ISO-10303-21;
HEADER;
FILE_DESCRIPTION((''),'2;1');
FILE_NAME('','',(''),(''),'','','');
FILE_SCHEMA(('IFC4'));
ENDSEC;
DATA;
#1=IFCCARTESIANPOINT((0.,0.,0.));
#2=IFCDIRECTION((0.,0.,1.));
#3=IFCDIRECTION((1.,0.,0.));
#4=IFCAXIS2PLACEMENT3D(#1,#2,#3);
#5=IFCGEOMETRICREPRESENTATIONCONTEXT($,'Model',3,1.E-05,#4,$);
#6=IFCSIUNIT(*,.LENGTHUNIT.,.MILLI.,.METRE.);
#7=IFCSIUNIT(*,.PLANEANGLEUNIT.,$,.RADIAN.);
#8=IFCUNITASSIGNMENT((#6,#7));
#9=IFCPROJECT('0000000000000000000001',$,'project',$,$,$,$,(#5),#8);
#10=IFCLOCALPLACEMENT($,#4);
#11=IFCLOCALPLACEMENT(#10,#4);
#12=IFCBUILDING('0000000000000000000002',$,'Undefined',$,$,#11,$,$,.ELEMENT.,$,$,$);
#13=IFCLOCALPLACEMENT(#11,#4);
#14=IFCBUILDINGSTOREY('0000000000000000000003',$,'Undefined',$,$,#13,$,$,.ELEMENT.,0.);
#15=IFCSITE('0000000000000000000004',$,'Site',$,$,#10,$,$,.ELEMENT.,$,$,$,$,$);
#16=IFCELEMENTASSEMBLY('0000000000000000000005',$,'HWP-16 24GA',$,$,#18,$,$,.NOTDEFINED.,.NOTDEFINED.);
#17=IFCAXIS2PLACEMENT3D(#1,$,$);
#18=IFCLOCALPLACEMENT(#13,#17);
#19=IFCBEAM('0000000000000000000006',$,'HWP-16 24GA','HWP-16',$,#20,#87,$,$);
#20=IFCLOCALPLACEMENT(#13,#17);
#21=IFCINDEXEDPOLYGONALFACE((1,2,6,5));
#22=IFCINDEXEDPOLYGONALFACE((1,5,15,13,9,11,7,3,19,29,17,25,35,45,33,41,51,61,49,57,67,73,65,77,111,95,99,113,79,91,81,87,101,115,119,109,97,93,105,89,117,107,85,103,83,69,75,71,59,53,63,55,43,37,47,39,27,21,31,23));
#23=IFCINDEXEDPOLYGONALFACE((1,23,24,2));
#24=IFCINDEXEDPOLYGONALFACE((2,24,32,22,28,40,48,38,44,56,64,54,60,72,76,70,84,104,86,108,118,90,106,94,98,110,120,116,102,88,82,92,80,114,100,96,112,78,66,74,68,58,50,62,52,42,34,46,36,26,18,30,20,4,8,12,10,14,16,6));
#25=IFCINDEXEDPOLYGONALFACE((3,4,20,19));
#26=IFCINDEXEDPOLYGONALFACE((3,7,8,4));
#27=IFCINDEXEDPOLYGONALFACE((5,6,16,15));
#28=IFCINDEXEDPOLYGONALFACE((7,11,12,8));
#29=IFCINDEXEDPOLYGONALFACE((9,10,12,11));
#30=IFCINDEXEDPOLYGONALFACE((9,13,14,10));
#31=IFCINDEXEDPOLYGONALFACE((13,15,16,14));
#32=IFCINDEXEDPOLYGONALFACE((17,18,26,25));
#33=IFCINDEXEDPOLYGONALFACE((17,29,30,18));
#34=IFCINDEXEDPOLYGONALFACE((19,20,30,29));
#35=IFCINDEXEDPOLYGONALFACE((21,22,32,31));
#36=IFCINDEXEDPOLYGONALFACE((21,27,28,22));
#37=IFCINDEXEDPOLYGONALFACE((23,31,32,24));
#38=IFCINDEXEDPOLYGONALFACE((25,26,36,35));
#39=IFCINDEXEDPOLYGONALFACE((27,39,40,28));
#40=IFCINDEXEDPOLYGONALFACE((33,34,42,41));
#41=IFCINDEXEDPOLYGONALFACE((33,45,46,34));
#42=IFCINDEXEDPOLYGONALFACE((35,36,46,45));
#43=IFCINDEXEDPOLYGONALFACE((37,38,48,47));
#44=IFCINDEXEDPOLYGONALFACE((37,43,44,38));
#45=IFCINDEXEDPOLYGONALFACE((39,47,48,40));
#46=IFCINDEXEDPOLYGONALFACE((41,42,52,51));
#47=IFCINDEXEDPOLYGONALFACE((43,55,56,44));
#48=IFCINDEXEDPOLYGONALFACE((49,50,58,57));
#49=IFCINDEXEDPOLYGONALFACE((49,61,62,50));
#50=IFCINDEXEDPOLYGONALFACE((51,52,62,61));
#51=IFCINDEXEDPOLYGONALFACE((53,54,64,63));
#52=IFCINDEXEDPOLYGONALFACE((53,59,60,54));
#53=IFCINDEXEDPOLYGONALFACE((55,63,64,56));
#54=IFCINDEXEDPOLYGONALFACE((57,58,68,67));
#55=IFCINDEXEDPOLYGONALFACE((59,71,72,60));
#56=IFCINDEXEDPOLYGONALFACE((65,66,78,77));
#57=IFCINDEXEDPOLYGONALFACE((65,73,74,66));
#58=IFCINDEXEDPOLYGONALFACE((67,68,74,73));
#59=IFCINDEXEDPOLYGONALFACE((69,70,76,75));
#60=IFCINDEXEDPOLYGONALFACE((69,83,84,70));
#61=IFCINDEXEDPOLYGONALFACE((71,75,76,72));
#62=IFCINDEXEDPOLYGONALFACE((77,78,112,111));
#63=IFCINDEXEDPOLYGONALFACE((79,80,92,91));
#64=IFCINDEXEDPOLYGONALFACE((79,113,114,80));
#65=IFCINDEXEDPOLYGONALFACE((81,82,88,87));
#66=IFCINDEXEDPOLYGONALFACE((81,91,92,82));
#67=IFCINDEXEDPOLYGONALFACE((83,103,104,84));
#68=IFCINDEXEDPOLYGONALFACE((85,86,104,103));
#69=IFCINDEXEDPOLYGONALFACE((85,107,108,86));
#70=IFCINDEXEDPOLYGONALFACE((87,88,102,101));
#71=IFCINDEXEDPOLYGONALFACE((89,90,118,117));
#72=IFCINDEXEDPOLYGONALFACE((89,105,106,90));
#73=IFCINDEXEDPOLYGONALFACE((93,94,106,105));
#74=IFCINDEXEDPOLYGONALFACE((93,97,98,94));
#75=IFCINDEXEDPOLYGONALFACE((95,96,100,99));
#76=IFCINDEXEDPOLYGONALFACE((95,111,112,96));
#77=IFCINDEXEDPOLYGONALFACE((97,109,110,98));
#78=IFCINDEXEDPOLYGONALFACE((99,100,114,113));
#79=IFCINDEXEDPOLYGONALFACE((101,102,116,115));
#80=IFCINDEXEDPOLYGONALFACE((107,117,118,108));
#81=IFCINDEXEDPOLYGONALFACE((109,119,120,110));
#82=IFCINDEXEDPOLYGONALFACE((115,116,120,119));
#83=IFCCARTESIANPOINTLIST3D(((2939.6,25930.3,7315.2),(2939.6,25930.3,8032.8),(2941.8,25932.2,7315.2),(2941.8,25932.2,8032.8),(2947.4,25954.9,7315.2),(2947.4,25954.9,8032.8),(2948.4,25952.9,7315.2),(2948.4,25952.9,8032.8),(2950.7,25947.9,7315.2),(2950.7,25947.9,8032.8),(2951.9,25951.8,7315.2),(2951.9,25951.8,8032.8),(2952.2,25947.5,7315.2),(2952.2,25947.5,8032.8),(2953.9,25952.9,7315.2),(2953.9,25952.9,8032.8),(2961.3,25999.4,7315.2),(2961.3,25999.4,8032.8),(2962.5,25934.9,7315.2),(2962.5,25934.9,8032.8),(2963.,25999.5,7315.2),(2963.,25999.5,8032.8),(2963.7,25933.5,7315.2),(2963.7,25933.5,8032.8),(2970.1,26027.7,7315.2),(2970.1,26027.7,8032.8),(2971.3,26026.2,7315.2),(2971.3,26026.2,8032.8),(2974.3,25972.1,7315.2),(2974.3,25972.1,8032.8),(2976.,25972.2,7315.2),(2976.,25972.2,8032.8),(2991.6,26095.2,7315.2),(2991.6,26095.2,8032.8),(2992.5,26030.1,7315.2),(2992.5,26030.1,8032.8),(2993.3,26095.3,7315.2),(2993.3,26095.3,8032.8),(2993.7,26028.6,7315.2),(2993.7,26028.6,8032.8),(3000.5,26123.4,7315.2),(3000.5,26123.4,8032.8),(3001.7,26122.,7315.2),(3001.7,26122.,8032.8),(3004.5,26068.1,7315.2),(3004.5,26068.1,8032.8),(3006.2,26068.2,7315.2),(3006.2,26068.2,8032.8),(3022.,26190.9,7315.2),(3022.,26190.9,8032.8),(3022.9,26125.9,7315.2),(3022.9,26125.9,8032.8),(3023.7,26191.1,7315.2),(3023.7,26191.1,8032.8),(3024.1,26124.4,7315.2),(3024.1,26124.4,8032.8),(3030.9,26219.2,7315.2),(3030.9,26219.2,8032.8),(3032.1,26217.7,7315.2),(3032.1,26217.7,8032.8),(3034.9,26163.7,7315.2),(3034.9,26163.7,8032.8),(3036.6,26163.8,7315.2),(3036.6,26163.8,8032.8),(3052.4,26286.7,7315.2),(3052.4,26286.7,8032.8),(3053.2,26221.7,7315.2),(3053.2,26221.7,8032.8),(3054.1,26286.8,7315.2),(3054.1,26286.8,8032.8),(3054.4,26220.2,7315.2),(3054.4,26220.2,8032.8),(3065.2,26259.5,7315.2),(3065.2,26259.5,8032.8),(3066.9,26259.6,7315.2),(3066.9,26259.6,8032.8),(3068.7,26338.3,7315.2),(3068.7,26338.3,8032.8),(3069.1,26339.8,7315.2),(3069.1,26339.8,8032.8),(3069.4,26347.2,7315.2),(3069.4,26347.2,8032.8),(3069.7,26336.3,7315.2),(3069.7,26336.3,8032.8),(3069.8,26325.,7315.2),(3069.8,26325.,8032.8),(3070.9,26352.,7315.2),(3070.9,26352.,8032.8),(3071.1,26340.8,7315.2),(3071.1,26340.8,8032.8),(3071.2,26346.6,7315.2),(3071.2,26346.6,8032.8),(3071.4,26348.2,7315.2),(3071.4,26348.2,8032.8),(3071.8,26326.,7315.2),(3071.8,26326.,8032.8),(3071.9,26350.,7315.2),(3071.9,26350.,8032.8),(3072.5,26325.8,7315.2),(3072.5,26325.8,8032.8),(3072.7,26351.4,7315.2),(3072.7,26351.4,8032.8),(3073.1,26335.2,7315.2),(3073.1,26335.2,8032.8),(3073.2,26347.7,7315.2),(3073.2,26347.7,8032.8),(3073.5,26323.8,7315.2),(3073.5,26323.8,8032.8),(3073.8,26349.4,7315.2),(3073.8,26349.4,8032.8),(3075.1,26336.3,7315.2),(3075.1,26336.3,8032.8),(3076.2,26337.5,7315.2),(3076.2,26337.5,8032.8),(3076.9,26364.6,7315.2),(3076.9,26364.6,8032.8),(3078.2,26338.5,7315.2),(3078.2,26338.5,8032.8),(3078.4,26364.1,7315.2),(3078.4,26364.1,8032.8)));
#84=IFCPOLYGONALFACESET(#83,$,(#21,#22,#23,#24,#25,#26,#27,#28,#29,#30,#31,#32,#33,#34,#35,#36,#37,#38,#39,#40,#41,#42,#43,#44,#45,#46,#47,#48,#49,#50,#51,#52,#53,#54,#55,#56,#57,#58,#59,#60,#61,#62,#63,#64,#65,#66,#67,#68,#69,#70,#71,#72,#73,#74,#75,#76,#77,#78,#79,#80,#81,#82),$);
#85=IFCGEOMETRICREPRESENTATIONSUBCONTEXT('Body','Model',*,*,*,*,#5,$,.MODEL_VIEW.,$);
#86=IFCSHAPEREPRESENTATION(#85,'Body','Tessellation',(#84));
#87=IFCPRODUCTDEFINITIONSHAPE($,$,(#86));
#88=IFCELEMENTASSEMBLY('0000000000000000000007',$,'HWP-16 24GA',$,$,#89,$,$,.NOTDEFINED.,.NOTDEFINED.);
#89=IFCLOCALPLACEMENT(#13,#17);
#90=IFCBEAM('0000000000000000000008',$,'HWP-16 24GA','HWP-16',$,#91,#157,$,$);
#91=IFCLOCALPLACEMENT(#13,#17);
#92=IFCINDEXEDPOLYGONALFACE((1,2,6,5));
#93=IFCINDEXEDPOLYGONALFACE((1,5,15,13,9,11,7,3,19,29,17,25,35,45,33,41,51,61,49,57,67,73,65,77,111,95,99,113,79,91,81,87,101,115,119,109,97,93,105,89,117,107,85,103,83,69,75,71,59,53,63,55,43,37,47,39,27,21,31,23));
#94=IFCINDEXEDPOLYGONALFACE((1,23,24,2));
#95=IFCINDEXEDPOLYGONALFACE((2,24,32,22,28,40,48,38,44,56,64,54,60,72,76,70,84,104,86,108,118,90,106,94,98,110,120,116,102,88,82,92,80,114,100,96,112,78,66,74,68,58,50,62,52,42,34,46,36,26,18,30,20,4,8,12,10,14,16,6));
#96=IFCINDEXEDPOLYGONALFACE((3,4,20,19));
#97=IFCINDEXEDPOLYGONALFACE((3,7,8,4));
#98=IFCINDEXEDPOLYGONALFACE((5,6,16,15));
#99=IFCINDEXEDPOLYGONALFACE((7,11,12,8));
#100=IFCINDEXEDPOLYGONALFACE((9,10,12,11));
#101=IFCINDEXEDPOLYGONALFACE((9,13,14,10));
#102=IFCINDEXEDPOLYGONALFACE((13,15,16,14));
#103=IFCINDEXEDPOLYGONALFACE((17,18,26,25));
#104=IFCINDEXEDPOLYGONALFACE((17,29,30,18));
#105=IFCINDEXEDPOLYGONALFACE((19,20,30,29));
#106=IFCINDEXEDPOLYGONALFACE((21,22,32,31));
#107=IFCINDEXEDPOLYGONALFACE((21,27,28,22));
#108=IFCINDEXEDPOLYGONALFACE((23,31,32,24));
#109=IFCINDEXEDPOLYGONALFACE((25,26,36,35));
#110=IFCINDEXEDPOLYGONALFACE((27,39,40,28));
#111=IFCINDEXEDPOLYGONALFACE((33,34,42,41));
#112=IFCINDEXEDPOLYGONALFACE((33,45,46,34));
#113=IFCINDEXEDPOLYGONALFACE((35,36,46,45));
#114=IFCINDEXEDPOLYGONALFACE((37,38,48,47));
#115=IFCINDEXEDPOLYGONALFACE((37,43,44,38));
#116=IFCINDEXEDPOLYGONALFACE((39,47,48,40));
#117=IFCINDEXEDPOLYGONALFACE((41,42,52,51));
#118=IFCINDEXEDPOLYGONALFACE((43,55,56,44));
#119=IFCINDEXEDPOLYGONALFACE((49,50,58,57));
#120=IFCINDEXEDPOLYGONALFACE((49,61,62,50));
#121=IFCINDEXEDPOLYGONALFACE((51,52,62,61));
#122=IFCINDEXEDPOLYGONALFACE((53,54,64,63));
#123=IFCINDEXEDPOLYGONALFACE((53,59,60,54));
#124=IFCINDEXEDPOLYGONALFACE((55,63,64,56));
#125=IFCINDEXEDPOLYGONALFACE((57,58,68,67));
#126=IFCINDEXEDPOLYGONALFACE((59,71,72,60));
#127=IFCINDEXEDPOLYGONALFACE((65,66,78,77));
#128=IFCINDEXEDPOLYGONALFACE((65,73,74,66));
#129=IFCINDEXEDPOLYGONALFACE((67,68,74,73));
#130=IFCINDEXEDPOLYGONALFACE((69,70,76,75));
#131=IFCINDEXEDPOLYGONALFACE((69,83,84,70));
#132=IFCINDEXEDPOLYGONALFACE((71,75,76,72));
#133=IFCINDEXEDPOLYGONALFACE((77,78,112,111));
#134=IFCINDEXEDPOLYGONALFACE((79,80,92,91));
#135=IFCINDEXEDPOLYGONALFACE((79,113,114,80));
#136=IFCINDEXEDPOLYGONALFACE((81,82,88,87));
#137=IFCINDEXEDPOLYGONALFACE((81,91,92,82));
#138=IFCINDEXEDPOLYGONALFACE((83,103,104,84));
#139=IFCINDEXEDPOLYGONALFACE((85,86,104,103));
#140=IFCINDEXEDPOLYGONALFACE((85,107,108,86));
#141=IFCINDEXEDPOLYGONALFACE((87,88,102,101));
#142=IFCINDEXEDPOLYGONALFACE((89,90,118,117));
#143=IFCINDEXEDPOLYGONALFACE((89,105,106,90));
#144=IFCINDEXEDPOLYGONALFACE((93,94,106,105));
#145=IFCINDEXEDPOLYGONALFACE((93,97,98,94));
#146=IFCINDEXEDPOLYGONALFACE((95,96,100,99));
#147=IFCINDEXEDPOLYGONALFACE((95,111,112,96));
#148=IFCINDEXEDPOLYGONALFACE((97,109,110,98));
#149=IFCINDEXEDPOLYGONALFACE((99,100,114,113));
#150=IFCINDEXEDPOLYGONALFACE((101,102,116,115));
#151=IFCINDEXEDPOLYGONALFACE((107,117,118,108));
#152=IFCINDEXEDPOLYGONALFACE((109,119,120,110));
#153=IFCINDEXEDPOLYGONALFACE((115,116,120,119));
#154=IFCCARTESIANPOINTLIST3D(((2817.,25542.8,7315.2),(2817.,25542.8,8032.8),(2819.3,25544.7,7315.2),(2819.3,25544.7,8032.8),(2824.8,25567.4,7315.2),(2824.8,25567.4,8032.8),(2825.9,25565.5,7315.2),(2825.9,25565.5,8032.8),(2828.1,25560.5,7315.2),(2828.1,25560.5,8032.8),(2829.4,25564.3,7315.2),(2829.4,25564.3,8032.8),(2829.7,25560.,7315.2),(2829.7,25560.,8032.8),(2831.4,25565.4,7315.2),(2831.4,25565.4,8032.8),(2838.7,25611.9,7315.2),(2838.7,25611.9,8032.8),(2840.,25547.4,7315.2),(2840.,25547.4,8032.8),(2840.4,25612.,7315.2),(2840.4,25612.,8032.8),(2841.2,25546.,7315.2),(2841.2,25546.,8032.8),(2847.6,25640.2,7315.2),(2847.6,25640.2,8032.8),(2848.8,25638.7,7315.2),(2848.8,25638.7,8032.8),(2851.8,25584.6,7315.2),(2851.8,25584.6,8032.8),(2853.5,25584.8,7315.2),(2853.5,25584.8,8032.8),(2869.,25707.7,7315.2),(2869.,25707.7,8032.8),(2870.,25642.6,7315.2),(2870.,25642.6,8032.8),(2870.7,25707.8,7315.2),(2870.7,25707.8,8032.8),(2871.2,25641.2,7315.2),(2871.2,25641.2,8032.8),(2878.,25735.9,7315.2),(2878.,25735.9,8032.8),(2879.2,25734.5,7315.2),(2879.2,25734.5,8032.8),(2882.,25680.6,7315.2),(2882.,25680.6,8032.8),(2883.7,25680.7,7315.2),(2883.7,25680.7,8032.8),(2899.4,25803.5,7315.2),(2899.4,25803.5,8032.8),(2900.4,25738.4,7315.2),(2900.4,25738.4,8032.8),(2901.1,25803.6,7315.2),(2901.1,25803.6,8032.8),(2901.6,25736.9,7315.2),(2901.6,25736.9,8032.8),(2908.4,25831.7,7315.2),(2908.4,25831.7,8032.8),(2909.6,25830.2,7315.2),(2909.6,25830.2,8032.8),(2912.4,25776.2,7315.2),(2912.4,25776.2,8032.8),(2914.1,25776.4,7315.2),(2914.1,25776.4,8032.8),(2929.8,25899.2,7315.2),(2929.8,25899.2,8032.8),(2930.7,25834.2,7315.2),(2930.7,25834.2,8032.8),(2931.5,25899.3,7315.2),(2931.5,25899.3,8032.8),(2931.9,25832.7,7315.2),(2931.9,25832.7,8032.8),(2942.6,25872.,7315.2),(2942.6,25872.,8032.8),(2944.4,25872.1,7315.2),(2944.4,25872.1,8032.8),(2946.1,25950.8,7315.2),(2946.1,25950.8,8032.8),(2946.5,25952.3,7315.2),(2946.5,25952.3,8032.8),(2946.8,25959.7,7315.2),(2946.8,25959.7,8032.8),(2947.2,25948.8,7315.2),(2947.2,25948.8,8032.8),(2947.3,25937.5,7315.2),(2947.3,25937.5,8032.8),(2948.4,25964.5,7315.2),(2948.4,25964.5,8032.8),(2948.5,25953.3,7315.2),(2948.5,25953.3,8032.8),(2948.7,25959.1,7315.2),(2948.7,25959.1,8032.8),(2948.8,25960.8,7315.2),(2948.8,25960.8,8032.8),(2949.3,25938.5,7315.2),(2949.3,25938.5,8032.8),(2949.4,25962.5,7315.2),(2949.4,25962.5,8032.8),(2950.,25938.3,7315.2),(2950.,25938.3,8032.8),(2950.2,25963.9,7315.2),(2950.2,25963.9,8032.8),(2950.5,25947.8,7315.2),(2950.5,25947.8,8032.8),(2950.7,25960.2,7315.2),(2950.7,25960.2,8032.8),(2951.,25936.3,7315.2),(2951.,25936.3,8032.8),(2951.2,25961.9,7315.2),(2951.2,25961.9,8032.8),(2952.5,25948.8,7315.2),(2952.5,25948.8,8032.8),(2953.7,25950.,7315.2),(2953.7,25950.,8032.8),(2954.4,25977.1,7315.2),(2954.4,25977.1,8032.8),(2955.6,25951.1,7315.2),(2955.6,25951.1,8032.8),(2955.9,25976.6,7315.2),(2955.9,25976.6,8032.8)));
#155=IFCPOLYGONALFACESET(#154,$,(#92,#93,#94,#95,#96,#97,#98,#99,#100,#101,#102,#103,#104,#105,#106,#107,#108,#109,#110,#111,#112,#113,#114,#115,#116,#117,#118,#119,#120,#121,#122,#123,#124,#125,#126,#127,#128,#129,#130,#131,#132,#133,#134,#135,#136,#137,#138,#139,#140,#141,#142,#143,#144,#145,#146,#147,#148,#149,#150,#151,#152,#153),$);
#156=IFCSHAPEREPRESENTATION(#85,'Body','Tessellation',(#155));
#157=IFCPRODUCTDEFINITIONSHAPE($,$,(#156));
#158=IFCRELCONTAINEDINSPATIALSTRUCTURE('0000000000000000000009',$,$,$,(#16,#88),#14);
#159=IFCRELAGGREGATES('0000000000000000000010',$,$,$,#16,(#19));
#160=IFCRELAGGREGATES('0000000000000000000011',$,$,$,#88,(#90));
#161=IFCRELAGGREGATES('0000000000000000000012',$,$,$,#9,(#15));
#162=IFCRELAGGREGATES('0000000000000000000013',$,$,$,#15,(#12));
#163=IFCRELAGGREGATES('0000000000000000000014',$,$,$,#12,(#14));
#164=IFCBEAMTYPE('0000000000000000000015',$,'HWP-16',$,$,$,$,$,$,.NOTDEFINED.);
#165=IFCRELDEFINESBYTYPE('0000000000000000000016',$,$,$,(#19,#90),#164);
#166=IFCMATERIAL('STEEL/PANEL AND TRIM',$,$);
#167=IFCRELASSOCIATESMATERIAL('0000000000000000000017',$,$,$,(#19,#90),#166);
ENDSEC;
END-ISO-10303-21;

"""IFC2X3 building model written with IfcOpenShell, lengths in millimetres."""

from ifc_helpers import new_model, si_unit, frame, origin_with_axes, place, context, subcontext, project, spatial, polyline, outline, extrude, clip, halfspace, material, type_object, element, aggregate, save


model = new_model("IFC2X3")

# Units and contexts
model_context = context("Model", 3, precision=1e-05, world=origin_with_axes())
body_context = subcontext(model_context, "Body", "Model", "MODEL_VIEW")
ifc_project = project(units=[si_unit("LENGTHUNIT", "METRE", prefix="MILLI"), si_unit("PLANEANGLEUNIT", "RADIAN")], contexts=[model_context])

# Site, building, storey
site_placement = place(None, origin_with_axes())
site = spatial("IfcSite", under=ifc_project, at=site_placement, Name="Site", CompositionType="ELEMENT")
building_placement = place(site_placement, origin_with_axes())
building = spatial("IfcBuilding", under=site, at=building_placement, Name="Undefined", CompositionType="ELEMENT")
storey_placement = place(building_placement, origin_with_axes())
storey = spatial("IfcBuildingStorey", under=building, at=storey_placement, Name="Undefined", CompositionType="ELEMENT", Elevation=0.0)

# Element assemblies, beams
ifc_material_1 = material(Name="STEEL/PANEL AND TRIM")
beam_type_1 = type_object("IfcBeamType", Name="HWP-16", PredefinedType="NOTDEFINED")
assembly_1_placement = place(storey_placement, origin_with_axes())
assembly_1 = element("IfcElementAssembly", 1, at=assembly_1_placement, inside=storey, Name="HWP-16 24GA", AssemblyPlace="NOTDEFINED", PredefinedType="NOTDEFINED")
beam_1_placement = place(assembly_1_placement, frame((2963.7, 25933.5, 8032.8), z_axis=(-0.953453, 0.301541, 0.0), x_axis=(0.0, 0.0, -1.0)))
beam_1 = element("IfcBeam", 2, at=beam_1_placement, type_object=beam_type_1, material=ifc_material_1, Name="HWP-16 24GA", Description="HWP-16", context=body_context, shape_type="Clipping", body=[
    clip(extrude(outline(polyline([(40.7, 0.0), (0.0, 0.0), (-10.3, 22.1), (15.5, 22.1), (15.5, 15.2), (9.9, 15.2), (9.9, 16.8), (13.9, 16.8), (13.9, 20.5), (-7.8, 20.5), (1.0, 1.6), (40.1, 1.6), (62.1, 22.2), (91.7, 22.3), (100.8, 1.7), (140.6, 1.7), (162.6, 22.2), (192.2, 22.2), (201.3, 1.6), (241.0, 1.6), (263.1, 22.1), (292.7, 22.1), (301.8, 1.6), (341.5, 1.6), (363.5, 22.0), (417.6, 22.0), (417.6, 15.3), (406.9, 15.3), (406.9, 14.6), (419.2, 14.6), (419.2, 22.1), (426.4, 22.1), (426.4, 24.0), (431.3, 24.0), (431.3, 22.1), (445.2, 22.1), (445.2, 20.5), (429.7, 20.5), (429.7, 22.5), (427.9, 22.5), (427.9, 20.5), (420.7, 20.5), (420.7, 13.0), (405.3, 13.0), (405.3, 16.9), (416.0, 16.9), (416.0, 20.4), (364.1, 20.4), (342.1, 0.0), (300.7, 0.0), (291.6, 20.5), (263.7, 20.5), (241.6, 0.0), (200.3, 0.0), (191.2, 20.6), (163.2, 20.6), (141.3, 0.1), (99.8, 0.1), (90.7, 20.7), (62.7, 20.6), (40.7, 0.0)])), frame((10000.0, 0.0, 0.0), z_axis=(-1.0, 0.0, 0.0), x_axis=(0.0, -1.0, 0.0)), (0.0, 0.0, 1.0), 10000.0), halfspace(frame((717.5, -500.0, -500.0), z_axis=(1.0, 0.0, 0.0), x_axis=(0.0, 0.0, 1.0)), False)),
])
aggregate(assembly_1, [beam_1])
assembly_2_placement = place(storey_placement, origin_with_axes())
assembly_2 = element("IfcElementAssembly", 3, at=assembly_2_placement, inside=storey, Name="HWP-16 24GA", AssemblyPlace="NOTDEFINED", PredefinedType="NOTDEFINED")
beam_2_placement = place(assembly_2_placement, frame((2841.2, 25546.0, 8032.8), z_axis=(-0.953453, 0.301541, 0.0), x_axis=(0.0, 0.0, -1.0)))
beam_2 = element("IfcBeam", 4, at=beam_2_placement, type_object=beam_type_1, material=ifc_material_1, Name="HWP-16 24GA", Description="HWP-16", context=body_context, shape_type="Clipping", body=[
    clip(extrude(outline(polyline([(40.7, 0.0), (0.0, 0.0), (-10.3, 22.1), (15.5, 22.1), (15.5, 15.2), (9.9, 15.2), (9.9, 16.8), (13.9, 16.8), (13.9, 20.5), (-7.8, 20.5), (1.0, 1.6), (40.1, 1.6), (62.1, 22.2), (91.7, 22.3), (100.8, 1.7), (140.6, 1.7), (162.6, 22.2), (192.2, 22.2), (201.3, 1.6), (241.0, 1.6), (263.1, 22.1), (292.7, 22.1), (301.8, 1.6), (341.5, 1.6), (363.5, 22.0), (417.6, 22.0), (417.6, 15.3), (406.9, 15.3), (406.9, 14.6), (419.2, 14.6), (419.2, 22.1), (426.4, 22.1), (426.4, 24.0), (431.3, 24.0), (431.3, 22.1), (445.2, 22.1), (445.2, 20.5), (429.7, 20.5), (429.7, 22.5), (427.9, 22.5), (427.9, 20.5), (420.7, 20.5), (420.7, 13.0), (405.3, 13.0), (405.3, 16.9), (416.0, 16.9), (416.0, 20.4), (364.1, 20.4), (342.1, 0.0), (300.7, 0.0), (291.6, 20.5), (263.7, 20.5), (241.6, 0.0), (200.3, 0.0), (191.2, 20.6), (163.2, 20.6), (141.3, 0.1), (99.8, 0.1), (90.7, 20.7), (62.7, 20.6), (40.7, 0.0)])), frame((10000.0, 0.0, 0.0), z_axis=(-1.0, 0.0, 0.0), x_axis=(0.0, -1.0, 0.0)), (0.0, 0.0, 1.0), 10000.0), halfspace(frame((717.5, -500.0, -500.0), z_axis=(1.0, 0.0, 0.0), x_axis=(0.0, 0.0, 1.0)), False)),
])
aggregate(assembly_2, [beam_2])

save(model, "model.ifc")
